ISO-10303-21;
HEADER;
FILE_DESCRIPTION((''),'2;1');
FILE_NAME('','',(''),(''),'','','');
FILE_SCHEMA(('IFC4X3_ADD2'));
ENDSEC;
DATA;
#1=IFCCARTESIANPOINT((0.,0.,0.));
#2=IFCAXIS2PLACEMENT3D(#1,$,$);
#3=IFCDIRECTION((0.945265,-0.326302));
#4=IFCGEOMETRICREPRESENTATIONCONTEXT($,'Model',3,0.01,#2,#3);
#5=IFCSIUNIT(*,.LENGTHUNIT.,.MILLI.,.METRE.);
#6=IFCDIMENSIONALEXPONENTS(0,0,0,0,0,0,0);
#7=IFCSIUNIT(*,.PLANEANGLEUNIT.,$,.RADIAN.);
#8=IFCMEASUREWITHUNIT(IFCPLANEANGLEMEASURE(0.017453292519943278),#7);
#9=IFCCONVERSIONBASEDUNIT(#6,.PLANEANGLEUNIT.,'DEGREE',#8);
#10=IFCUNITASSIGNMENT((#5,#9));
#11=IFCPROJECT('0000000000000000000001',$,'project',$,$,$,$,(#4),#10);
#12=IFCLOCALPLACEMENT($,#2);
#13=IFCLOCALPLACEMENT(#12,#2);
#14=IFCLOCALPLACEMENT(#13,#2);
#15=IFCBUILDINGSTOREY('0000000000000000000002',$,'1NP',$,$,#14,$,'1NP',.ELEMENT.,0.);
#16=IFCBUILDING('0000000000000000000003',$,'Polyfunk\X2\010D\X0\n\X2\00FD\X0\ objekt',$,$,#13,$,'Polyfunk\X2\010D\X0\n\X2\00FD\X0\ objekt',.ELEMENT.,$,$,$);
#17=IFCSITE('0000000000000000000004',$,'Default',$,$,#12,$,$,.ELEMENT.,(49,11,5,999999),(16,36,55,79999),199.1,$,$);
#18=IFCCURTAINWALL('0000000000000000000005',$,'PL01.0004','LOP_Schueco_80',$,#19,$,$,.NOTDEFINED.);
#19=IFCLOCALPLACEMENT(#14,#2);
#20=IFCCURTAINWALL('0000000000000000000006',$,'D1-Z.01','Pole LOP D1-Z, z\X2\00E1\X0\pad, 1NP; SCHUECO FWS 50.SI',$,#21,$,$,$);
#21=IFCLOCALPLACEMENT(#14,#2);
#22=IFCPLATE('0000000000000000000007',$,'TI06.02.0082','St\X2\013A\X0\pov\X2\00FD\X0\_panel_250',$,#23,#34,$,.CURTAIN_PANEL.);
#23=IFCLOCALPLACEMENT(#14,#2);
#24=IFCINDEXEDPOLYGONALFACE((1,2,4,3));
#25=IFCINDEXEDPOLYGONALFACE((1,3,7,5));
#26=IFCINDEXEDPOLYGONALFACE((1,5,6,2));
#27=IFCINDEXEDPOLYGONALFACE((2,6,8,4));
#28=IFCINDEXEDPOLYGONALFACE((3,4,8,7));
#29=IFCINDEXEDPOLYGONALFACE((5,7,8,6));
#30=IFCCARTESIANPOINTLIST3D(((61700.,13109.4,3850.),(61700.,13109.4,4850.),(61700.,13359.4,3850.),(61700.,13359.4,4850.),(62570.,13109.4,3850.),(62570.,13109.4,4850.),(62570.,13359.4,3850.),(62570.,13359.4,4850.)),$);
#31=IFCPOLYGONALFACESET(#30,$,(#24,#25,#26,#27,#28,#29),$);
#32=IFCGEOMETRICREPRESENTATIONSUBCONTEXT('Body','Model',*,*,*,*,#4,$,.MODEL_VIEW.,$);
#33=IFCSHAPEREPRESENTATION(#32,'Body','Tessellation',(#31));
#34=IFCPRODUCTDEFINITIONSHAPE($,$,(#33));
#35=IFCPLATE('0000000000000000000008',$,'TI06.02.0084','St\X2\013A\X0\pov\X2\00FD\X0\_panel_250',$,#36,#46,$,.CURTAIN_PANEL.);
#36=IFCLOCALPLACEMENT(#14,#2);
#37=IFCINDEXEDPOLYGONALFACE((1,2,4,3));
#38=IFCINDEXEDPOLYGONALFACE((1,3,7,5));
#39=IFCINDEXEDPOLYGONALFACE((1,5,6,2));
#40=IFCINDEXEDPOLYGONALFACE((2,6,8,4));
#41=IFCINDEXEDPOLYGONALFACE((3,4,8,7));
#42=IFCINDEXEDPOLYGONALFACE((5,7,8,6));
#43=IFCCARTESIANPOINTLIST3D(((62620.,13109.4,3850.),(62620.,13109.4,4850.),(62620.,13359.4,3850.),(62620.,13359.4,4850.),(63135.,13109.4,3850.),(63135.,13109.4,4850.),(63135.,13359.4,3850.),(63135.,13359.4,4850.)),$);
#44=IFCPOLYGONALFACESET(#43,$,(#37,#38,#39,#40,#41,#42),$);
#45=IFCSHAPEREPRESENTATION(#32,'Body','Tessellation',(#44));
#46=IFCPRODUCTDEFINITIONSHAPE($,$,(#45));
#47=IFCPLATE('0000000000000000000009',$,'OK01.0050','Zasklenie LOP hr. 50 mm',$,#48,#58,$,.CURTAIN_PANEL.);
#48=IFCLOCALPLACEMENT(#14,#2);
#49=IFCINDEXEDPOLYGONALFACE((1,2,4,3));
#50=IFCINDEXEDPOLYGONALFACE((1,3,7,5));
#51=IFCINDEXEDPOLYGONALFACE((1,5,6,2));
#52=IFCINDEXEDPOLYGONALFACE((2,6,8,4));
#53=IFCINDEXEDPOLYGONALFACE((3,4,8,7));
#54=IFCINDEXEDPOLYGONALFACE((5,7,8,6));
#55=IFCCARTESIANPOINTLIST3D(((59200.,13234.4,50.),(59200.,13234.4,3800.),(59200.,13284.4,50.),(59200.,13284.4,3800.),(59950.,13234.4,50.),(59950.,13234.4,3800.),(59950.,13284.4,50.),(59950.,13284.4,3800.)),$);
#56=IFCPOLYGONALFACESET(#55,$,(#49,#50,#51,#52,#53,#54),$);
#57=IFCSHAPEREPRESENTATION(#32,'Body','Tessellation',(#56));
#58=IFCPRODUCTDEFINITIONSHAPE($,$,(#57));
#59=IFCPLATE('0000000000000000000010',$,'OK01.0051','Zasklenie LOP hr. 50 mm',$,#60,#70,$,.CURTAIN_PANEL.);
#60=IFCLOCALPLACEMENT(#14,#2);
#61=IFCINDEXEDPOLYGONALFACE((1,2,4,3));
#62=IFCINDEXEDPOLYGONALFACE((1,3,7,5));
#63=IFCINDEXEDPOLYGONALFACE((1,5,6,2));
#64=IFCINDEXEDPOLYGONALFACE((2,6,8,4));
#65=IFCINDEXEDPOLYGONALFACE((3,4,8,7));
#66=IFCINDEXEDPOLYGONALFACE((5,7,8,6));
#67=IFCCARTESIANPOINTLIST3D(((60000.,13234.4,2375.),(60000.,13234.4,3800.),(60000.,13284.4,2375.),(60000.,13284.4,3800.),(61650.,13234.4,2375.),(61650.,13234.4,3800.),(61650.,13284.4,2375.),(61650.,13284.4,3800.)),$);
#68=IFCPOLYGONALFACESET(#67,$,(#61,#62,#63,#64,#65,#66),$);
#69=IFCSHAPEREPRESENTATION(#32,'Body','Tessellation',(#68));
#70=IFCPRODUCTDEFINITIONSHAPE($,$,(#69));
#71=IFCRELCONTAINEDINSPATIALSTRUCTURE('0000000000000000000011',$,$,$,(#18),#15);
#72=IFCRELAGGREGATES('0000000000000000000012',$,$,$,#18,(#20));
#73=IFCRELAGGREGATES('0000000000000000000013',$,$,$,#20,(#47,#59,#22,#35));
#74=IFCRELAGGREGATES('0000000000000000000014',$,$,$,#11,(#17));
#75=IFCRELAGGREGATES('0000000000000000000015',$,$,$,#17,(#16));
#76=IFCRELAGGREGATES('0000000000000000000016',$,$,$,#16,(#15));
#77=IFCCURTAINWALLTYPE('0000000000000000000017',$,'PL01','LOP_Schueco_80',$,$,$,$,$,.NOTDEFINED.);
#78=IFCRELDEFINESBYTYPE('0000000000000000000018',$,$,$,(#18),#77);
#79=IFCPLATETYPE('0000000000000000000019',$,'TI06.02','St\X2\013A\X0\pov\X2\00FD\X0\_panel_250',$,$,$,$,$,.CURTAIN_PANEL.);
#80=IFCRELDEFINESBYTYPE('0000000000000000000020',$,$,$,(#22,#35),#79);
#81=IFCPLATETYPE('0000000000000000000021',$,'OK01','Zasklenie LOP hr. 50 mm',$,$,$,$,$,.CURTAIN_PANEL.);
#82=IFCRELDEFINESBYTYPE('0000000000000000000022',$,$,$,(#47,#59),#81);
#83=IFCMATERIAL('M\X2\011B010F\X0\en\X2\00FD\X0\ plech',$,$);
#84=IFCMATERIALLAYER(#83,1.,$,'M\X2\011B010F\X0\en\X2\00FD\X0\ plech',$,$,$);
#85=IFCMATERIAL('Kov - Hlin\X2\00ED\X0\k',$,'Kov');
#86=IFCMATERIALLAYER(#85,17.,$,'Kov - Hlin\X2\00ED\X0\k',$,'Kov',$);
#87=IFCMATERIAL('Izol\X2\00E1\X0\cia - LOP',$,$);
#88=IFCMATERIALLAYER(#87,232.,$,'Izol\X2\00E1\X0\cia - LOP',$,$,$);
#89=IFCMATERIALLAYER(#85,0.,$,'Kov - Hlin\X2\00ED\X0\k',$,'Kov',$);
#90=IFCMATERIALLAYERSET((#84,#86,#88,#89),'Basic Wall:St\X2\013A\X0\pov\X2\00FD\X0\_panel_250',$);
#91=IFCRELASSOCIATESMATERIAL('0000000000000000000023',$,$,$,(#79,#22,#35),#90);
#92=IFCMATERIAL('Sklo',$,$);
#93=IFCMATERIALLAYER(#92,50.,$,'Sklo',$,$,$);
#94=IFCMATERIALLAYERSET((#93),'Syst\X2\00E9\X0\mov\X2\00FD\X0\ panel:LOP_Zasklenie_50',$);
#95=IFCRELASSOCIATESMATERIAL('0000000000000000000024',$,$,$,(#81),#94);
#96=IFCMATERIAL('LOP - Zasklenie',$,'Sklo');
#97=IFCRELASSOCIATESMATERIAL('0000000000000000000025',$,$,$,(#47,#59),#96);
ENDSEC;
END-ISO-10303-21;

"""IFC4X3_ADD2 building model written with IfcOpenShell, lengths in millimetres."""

from ifc_helpers import new_model, entity, si_unit, converted_unit, direction, frame, frame_2d, origin, origin_2d_with_axis, place, context, subcontext, project, spatial, rectangle, extrude, source, transform, mapped, material, layer, layer_set, layer_usage, type_object, type_shapes, element, aggregate, save


model = new_model("IFC4X3_ADD2")

# Units and contexts
model_context = context("Model", 3, precision=0.01, world=origin(), true_north=direction((0.945265, -0.326302)))
body_context = subcontext(model_context, "Body", "Model", "MODEL_VIEW")
ifc_project = project(units=[si_unit("LENGTHUNIT", "METRE", prefix="MILLI"), converted_unit("PLANEANGLEUNIT", "DEGREE", entity("IfcPlaneAngleMeasure", 0.017453292519943278), si_unit("PLANEANGLEUNIT", "RADIAN"), dimensions=[0, 0, 0, 0, 0, 0, 0])], contexts=[model_context])

# Site, building, storey
site_placement = place(None, origin())
site = spatial("IfcSite", under=ifc_project, at=site_placement, Name="Default", CompositionType="ELEMENT", RefLatitude=(49, 11, 5, 999999), RefLongitude=(16, 36, 55, 79999), RefElevation=199.1)
building_placement = place(site_placement, origin())
building = spatial("IfcBuilding", under=site, at=building_placement, Name="Polyfunkčný objekt", LongName="Polyfunkčný objekt", CompositionType="ELEMENT")
storey_placement = place(building_placement, origin())
storey = spatial("IfcBuildingStorey", under=building, at=storey_placement, Name="1NP", LongName="1NP", CompositionType="ELEMENT", Elevation=0.0)

# Curtain walls, plates
curtain_wall_type = type_object("IfcCurtainWallType", Name="PL01", Description="LOP_Schueco_80", PredefinedType="NOTDEFINED")
curtain_wall_1_placement = place(storey_placement, origin())
curtain_wall_1 = element("IfcCurtainWall", 1, at=curtain_wall_1_placement, inside=storey, type_object=curtain_wall_type, Name="PL01.0004", Description="LOP_Schueco_80", PredefinedType="NOTDEFINED")
curtain_wall_2 = element("IfcCurtainWall", 2, Name="D1-Z.01", Description="Pole LOP D1-Z, západ, 1NP; SCHUECO FWS 50.SI")
aggregate(curtain_wall_1, [curtain_wall_2])
ifc_material_1 = material(Name="Měďený plech")
ifc_layer_1 = layer(ifc_material_1, 1.0, Name="Měďený plech")
ifc_material_2 = material(Name="Kov - Hliník", Category="Kov")
ifc_layer_2 = layer(ifc_material_2, 17.0, Name="Kov - Hliník", Category="Kov")
ifc_material_3 = material(Name="Izolácia - LOP")
ifc_layer_3 = layer(ifc_material_3, 232.0, Name="Izolácia - LOP")
ifc_layer_4 = layer(ifc_material_2, 0.0, Name="Kov - Hliník", Category="Kov")
ifc_layer_set_1 = layer_set([ifc_layer_1, ifc_layer_2, ifc_layer_3, ifc_layer_4], Name="Basic Wall:Stĺpový_panel_250")
ifc_layer_usage_1 = layer_usage(ifc_layer_set_1, "AXIS2", "NEGATIVE", 125.0)
plate_type_1 = type_object("IfcPlateType", Name="TI06.02", Description="Stĺpový_panel_250", PredefinedType="CURTAIN_PANEL", material=ifc_layer_set_1)
plate_1_placement = place(storey_placement, frame((61700.0, 13234.4, 3850.0)))
plate_1 = element("IfcPlate", 3, at=plate_1_placement, type_object=plate_type_1, material=ifc_layer_usage_1, Name="TI06.02.0082", Description="Stĺpový_panel_250", PredefinedType="CURTAIN_PANEL", context=body_context, shape_type="SweptSolid", body=[
    extrude(rectangle(XDim=250.0, YDim=870.0, at=frame_2d((0.0, 0.0), x_axis=(1.0, 0.0))), frame((435.0, 0.0, 0.0), z_axis=(0.0, 0.0, 1.0), x_axis=(0.0, 1.0, 0.0)), (0.0, 0.0, 1.0), 1000.0),
])
ifc_layer_usage_2 = layer_usage(ifc_layer_set_1, "AXIS2", "NEGATIVE", 125.0)
plate_2_placement = place(storey_placement, frame((62620.0, 13234.4, 3850.0)))
plate_2 = element("IfcPlate", 4, at=plate_2_placement, type_object=plate_type_1, material=ifc_layer_usage_2, Name="TI06.02.0084", Description="Stĺpový_panel_250", PredefinedType="CURTAIN_PANEL", context=body_context, shape_type="SweptSolid", body=[
    extrude(rectangle(XDim=250.0, YDim=515.0, at=frame_2d((0.0, 0.0), x_axis=(1.0, 0.0))), frame((257.5, 0.0, 0.0), z_axis=(0.0, 0.0, 1.0), x_axis=(0.0, 1.0, 0.0)), (0.0, 0.0, 1.0), 1000.0),
])

# Plates
ifc_material_4 = material(Name="LOP - Zasklenie", Category="Sklo")
ifc_material_5 = material(Name="Sklo")
ifc_layer_5 = layer(ifc_material_5, 50.0, Name="Sklo")
ifc_layer_set_2 = layer_set([ifc_layer_5], Name="Systémový panel:LOP_Zasklenie_50")
plate_type_2 = type_object("IfcPlateType", Name="OK01", Description="Zasklenie LOP hr. 50 mm", PredefinedType="CURTAIN_PANEL", material=ifc_layer_set_2)
shared_shape_1 = source(origin(), body_context, "Body", "SweptSolid", [
    extrude(rectangle(XDim=3750.0, YDim=750.0, at=frame_2d((-141.7, 0.0), x_axis=(1.0, 0.0))), frame((0.0, 0.0, 2016.7), z_axis=(0.0, 1.0, 0.0), x_axis=(0.0, 0.0, 1.0)), (0.0, 0.0, 1.0), 50.0),
])
plate_3_placement = place(curtain_wall_1_placement, frame((59575.0, 13234.4, 50.0)))
plate_3 = element("IfcPlate", 5, at=plate_3_placement, type_object=plate_type_2, material=ifc_material_4, Name="OK01.0050", Description="Zasklenie LOP hr. 50 mm", PredefinedType="CURTAIN_PANEL", context=body_context, shape_type="MappedRepresentation", body=[
    mapped(shared_shape_1, transform((0.0, 0.0, 0.0), scale=1.0)),
])
shared_shape_2 = source(origin(), body_context, "Body", "SweptSolid", [
    extrude(rectangle(XDim=50.0, YDim=1650.0, at=origin_2d_with_axis()), frame((0.0, 25.0, 0.0), z_axis=(0.0, 0.0, 1.0), x_axis=(0.0, 1.0, 0.0)), (0.0, 0.0, 1.0), 1425.0),
])
type_shapes(plate_type_2, [shared_shape_1, shared_shape_2])
plate_4_placement = place(curtain_wall_1_placement, frame((60825.0, 13234.4, 2375.0)))
plate_4 = element("IfcPlate", 6, at=plate_4_placement, type_object=plate_type_2, material=ifc_material_4, Name="OK01.0051", Description="Zasklenie LOP hr. 50 mm", PredefinedType="CURTAIN_PANEL", context=body_context, shape_type="MappedRepresentation", body=[
    mapped(shared_shape_2, transform((0.0, 0.0, 0.0), scale=1.0)),
])
aggregate(curtain_wall_2, [plate_3, plate_4, plate_1, plate_2])

save(model, "model.ifc")
